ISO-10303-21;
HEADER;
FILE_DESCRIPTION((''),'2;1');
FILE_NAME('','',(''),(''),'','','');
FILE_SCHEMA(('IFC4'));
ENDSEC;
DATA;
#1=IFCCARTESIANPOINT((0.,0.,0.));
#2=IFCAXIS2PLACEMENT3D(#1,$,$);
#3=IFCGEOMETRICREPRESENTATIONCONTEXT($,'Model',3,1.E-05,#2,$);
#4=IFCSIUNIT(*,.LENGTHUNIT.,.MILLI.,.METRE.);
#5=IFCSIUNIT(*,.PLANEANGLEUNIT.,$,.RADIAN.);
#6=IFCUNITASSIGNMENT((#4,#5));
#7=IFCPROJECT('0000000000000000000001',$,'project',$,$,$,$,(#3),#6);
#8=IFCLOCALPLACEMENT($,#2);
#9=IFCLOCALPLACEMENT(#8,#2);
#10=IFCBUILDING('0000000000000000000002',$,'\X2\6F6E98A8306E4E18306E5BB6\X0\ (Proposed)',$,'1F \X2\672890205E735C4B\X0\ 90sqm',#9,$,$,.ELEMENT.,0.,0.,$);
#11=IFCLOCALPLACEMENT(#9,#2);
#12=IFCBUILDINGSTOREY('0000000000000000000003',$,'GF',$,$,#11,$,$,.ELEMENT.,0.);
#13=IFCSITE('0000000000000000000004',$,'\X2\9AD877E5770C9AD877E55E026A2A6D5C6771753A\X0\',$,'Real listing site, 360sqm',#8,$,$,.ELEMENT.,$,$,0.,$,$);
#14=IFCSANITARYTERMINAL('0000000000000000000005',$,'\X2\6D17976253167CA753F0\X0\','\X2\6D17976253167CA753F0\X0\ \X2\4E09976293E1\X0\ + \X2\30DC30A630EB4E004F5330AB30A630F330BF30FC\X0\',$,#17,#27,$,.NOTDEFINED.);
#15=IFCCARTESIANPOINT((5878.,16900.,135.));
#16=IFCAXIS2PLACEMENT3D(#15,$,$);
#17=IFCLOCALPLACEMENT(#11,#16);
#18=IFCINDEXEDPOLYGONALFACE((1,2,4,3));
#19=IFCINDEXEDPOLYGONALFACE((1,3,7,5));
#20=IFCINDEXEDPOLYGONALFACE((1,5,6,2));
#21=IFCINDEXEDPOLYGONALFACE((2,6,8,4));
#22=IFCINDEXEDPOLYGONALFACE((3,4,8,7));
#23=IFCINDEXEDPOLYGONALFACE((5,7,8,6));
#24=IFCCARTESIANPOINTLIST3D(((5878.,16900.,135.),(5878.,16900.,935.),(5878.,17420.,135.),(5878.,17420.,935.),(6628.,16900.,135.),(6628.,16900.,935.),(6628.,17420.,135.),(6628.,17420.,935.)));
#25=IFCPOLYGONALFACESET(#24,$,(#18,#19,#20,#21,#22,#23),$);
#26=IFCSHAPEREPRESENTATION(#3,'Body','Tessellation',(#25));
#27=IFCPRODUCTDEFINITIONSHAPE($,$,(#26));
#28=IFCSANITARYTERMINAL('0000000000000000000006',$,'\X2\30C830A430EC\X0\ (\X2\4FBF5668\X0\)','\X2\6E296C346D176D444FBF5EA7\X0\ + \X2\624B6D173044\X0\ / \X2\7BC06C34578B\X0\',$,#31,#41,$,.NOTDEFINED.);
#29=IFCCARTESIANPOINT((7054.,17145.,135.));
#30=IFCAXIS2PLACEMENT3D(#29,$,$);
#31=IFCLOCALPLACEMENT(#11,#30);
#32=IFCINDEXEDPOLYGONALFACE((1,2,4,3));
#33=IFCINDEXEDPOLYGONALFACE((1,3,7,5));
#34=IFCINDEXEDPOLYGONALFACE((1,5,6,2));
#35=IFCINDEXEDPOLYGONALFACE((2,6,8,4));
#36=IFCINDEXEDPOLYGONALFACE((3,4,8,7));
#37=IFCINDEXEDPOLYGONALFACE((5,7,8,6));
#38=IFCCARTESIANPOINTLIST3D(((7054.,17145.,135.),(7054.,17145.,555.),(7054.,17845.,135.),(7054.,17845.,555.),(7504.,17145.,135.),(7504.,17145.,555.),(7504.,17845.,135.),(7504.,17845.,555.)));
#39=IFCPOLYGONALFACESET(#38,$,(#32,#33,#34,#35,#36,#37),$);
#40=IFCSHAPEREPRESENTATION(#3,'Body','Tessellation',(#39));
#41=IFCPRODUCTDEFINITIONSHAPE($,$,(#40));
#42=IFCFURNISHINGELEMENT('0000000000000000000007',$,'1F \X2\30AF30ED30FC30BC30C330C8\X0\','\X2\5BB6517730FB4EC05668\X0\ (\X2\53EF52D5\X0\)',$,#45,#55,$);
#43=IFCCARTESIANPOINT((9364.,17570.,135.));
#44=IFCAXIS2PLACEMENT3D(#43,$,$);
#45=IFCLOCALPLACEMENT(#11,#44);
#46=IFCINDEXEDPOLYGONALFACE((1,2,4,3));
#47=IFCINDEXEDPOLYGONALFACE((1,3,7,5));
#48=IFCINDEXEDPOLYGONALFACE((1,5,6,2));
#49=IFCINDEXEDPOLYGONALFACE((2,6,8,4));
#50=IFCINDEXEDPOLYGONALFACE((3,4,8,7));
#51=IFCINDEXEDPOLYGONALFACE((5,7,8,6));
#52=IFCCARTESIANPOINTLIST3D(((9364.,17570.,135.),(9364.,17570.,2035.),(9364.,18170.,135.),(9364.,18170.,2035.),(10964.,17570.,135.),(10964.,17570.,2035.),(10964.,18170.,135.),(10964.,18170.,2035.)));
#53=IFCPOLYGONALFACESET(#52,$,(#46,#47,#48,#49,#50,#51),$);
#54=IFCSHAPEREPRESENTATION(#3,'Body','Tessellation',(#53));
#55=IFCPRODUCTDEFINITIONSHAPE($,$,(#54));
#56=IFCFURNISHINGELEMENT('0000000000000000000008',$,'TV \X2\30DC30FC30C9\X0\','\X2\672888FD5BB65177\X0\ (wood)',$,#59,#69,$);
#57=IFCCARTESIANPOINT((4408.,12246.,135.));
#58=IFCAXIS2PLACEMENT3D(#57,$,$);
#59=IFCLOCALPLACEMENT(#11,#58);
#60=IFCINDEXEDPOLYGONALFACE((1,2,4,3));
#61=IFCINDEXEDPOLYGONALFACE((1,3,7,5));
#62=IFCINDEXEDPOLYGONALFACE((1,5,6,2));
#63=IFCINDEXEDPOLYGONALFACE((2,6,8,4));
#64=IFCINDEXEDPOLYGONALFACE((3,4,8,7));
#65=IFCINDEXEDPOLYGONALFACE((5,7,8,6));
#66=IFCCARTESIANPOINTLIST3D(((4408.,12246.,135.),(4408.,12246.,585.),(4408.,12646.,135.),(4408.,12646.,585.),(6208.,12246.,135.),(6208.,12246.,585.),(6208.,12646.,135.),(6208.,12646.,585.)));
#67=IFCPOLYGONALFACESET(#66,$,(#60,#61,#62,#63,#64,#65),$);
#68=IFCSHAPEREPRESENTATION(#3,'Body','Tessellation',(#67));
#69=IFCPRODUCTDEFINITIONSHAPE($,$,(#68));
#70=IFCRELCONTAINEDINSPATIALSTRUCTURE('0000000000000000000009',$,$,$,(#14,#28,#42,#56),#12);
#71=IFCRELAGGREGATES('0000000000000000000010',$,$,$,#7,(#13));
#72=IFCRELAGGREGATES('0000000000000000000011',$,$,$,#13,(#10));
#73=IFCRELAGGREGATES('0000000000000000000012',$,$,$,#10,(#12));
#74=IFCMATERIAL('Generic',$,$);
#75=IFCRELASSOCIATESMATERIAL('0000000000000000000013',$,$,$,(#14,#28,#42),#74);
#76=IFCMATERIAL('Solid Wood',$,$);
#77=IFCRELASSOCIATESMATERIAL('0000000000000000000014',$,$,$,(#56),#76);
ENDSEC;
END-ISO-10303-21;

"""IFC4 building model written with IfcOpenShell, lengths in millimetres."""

from ifc_helpers import new_model, si_unit, frame, frame_2d, origin, place, context, project, spatial, rectangle, extrude, material, element, save


model = new_model("IFC4")

# Units and contexts
model_context = context("Model", 3, precision=1e-05, world=origin())
ifc_project = project(units=[si_unit("LENGTHUNIT", "METRE", prefix="MILLI"), si_unit("PLANEANGLEUNIT", "RADIAN")], contexts=[model_context])

# Site, building, storey
site_placement = place(None, origin())
site = spatial("IfcSite", under=ifc_project, at=site_placement, Name="高知県高知市横浜東町", ObjectType="Real listing site, 360sqm", CompositionType="ELEMENT", RefElevation=0.0)
building_placement = place(site_placement, origin())
building = spatial("IfcBuilding", under=site, at=building_placement, Name="潮風の丘の家 (Proposed)", ObjectType="1F 木造平屋 90sqm", CompositionType="ELEMENT", ElevationOfRefHeight=0.0, ElevationOfTerrain=0.0)
storey_placement = place(building_placement, origin())
storey = spatial("IfcBuildingStorey", under=building, at=storey_placement, Name="GF", CompositionType="ELEMENT", Elevation=0.0)

# Shared definitions
ifc_material_1 = material(Name="Solid Wood")

# Sanitary terminals
ifc_material_2 = material(Name="Generic")
sanitary_terminal_1_placement = place(storey_placement, frame((5878.0, 16900.0, 135.0)))
element("IfcSanitaryTerminal", 1, at=sanitary_terminal_1_placement, inside=storey, material=ifc_material_2, Name="洗面化粧台", Description="洗面化粧台 三面鏡 + ボウル一体カウンター", PredefinedType="NOTDEFINED", context=model_context, shape_type="SweptSolid", body=[
    extrude(rectangle(XDim=750.0, YDim=520.0, at=frame_2d((375.0, 260.0))), frame((5878.0, 16900.0, 135.0)), (0.0, 0.0, 1.0), 800.0),
])
sanitary_terminal_2_placement = place(storey_placement, frame((7054.0, 17145.0, 135.0)))
element("IfcSanitaryTerminal", 2, at=sanitary_terminal_2_placement, inside=storey, material=ifc_material_2, Name="トイレ (便器)", Description="温水洗浄便座 + 手洗い / 節水型", PredefinedType="NOTDEFINED", context=model_context, shape_type="SweptSolid", body=[
    extrude(rectangle(XDim=450.0, YDim=700.0, at=frame_2d((225.0, 350.0))), frame((7054.0, 17145.0, 135.0)), (0.0, 0.0, 1.0), 420.0),
])

# Furnishing elements
furnishing_1_placement = place(storey_placement, frame((9364.0, 17570.0, 135.0)))
element("IfcFurnishingElement", 3, at=furnishing_1_placement, inside=storey, material=ifc_material_2, Name="1F クローゼット", Description="家具・什器 (可動)", context=model_context, shape_type="SweptSolid", body=[
    extrude(rectangle(XDim=1600.0, YDim=600.0, at=frame_2d((800.0, 300.0))), frame((9364.0, 17570.0, 135.0)), (0.0, 0.0, 1.0), 1900.0),
])
furnishing_2_placement = place(storey_placement, frame((4408.0, 12246.0, 135.0)))
element("IfcFurnishingElement", 4, at=furnishing_2_placement, inside=storey, material=ifc_material_1, Name="TV ボード", Description="木製家具 (wood)", context=model_context, shape_type="SweptSolid", body=[
    extrude(rectangle(XDim=1800.0, YDim=400.0, at=frame_2d((900.0, 200.0))), frame((4408.0, 12246.0, 135.0)), (0.0, 0.0, 1.0), 450.0),
])

save(model, "model.ifc")
